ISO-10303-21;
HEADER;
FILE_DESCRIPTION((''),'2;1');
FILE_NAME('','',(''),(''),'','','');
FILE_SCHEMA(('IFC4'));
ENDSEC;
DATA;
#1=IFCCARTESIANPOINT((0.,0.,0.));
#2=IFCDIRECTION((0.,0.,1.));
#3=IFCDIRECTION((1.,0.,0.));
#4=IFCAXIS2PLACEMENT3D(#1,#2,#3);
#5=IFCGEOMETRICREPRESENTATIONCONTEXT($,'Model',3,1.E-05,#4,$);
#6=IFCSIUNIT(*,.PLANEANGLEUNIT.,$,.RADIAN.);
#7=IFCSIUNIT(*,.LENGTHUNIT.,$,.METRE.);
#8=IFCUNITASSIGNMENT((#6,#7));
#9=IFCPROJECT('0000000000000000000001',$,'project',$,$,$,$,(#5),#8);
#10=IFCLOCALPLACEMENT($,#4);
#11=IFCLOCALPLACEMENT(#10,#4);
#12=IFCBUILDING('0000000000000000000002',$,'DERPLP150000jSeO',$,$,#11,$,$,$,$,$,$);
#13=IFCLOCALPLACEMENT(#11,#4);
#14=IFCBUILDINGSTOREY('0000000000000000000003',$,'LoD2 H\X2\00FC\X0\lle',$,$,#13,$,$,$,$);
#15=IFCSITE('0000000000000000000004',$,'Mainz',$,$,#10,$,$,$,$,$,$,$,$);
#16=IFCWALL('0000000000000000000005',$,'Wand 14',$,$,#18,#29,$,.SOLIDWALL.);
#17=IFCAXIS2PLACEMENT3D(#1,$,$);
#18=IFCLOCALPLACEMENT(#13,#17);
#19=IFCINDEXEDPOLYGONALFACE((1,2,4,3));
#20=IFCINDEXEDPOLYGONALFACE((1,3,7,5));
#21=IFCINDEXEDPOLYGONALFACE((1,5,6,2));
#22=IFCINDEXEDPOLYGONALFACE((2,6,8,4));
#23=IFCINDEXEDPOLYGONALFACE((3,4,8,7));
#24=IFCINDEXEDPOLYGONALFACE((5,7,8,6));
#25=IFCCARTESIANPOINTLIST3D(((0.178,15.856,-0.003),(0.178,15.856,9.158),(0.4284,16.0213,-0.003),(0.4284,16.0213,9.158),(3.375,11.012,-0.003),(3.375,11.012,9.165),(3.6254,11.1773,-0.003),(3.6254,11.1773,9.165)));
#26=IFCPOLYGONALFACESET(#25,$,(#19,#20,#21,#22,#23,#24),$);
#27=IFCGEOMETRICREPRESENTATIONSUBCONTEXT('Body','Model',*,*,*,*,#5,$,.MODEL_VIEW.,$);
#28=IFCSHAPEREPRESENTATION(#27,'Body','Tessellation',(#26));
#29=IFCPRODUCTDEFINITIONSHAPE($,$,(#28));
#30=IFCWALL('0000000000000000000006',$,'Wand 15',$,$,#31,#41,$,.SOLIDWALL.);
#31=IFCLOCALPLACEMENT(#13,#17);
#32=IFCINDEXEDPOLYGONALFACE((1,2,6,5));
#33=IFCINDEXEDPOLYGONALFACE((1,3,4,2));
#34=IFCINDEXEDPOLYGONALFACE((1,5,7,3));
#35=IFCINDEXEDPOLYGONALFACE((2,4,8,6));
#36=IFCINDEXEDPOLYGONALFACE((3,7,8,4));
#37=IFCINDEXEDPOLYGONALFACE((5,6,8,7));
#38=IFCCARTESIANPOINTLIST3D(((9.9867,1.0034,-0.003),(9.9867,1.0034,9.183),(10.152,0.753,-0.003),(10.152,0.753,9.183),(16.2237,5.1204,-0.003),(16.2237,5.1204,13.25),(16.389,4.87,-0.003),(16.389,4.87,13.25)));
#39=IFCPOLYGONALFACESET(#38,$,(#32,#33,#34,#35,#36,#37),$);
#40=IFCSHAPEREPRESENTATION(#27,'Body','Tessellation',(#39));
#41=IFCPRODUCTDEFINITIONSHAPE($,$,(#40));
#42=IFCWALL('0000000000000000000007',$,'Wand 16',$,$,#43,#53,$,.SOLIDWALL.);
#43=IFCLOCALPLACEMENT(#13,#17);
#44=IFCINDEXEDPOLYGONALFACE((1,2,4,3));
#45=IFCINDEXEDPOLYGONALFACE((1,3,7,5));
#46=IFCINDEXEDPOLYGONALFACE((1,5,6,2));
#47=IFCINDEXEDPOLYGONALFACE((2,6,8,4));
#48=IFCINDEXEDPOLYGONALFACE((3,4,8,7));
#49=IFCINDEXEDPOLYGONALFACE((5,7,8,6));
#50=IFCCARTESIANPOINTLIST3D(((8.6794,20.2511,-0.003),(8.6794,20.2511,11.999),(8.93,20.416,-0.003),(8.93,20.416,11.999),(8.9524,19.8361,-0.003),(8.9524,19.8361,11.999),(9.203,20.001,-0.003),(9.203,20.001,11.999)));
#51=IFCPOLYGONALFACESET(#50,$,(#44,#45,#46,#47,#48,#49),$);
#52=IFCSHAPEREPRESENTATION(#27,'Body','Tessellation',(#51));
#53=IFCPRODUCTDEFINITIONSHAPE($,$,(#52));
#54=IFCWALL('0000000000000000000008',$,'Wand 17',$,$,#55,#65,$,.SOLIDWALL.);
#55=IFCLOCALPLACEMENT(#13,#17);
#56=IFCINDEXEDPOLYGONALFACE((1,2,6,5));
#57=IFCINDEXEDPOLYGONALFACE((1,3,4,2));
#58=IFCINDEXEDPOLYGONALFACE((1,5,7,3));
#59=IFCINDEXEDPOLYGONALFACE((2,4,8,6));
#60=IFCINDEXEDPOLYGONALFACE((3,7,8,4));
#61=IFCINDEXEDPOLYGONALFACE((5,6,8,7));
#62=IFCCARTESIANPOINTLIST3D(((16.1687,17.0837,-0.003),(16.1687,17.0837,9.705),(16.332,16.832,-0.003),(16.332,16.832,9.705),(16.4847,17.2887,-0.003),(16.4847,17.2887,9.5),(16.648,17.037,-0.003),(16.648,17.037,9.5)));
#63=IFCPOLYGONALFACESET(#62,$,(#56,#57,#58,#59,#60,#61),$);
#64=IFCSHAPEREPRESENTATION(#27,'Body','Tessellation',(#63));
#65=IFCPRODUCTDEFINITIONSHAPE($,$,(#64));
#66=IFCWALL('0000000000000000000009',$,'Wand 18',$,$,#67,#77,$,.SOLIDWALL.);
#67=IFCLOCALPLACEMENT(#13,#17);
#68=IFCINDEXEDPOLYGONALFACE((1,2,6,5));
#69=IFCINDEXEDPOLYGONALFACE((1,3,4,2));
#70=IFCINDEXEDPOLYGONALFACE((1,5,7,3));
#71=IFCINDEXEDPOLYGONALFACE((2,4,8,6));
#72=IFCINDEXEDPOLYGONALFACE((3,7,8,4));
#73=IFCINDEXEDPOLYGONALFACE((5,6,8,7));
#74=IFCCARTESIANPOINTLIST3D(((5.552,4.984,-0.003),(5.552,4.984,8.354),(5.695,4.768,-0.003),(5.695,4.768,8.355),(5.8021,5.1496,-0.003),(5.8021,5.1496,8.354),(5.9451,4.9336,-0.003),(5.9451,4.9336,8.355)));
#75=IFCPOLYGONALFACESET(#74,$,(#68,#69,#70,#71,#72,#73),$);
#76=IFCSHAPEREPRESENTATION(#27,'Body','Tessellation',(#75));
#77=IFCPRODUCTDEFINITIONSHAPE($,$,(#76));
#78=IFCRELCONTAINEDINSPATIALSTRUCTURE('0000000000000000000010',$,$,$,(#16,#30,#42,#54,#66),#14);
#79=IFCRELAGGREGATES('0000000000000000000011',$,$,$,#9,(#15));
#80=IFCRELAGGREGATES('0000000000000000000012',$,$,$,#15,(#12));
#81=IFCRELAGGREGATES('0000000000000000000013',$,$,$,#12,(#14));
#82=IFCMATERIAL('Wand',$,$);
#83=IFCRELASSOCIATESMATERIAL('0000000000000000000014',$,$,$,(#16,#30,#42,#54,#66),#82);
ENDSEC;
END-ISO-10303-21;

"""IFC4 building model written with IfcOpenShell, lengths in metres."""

from ifc_helpers import new_model, si_unit, frame, origin_with_axes, place, context, subcontext, project, spatial, polyline, outline, extrude, material, element, save


model = new_model("IFC4")

# Units and contexts
model_context = context("Model", 3, precision=1e-05, world=origin_with_axes())
body_context = subcontext(model_context, "Body", "Model", "MODEL_VIEW")
ifc_project = project(units=[si_unit("PLANEANGLEUNIT", "RADIAN"), si_unit("LENGTHUNIT", "METRE")], contexts=[model_context])

# Site, building, storey
site_placement = place(None, origin_with_axes())
site = spatial("IfcSite", under=ifc_project, at=site_placement, Name="Mainz")
building_placement = place(site_placement, origin_with_axes())
building = spatial("IfcBuilding", under=site, at=building_placement, Name="DERPLP150000jSeO")
storey_placement = place(building_placement, origin_with_axes())
storey = spatial("IfcBuildingStorey", under=building, at=storey_placement, Name="LoD2 Hülle")

# Walls
ifc_material_1 = material(Name="Wand")
wall_1_placement = place(storey_placement, origin_with_axes())
element("IfcWall", 1, at=wall_1_placement, inside=storey, material=ifc_material_1, Name="Wand 14", PredefinedType="SOLIDWALL", context=body_context, shape_type="SweptSolid", body=[
    extrude(outline(polyline([(0.0, 0.0), (5.8039, 0.0), (5.8149, 9.161), (0.0111, 9.168), (0.0, 0.0)])), frame((3.375, 11.012, 9.165), z_axis=(-0.834613, -0.550837, 0.0), x_axis=(-0.550837, 0.834612, -0.001206)), (0.0, 0.0, -1.0), 0.3),
])
wall_2_placement = place(storey_placement, origin_with_axes())
element("IfcWall", 2, at=wall_2_placement, inside=storey, material=ifc_material_1, Name="Wand 15", PredefinedType="SOLIDWALL", context=body_context, shape_type="SweptSolid", body=[
    extrude(outline(polyline([(0.0, 0.0), (8.5083, 0.0), (12.8992, 8.0686), (6.335, 11.6409), (0.0, 0.0)])), frame((16.389, 4.87, 13.25), z_axis=(0.550896, -0.834574, 0.0), x_axis=(-0.733053, -0.483883, -0.478007)), (0.0, 0.0, -1.0), 0.3),
])
wall_3_placement = place(storey_placement, origin_with_axes())
element("IfcWall", 3, at=wall_3_placement, inside=storey, material=ifc_material_1, Name="Wand 16", PredefinedType="SOLIDWALL", context=body_context, shape_type="SweptSolid", body=[
    extrude(outline(polyline([(0.0, 0.0), (0.4967, 0.0), (0.4967, 12.002), (0.0, 12.002), (0.0, 0.0)])), frame((8.93, 20.416, 11.999), z_axis=(0.835441, 0.54958, 0.0), x_axis=(0.54958, -0.835441, 0.0)), (0.0, 0.0, -1.0), 0.3),
])
wall_4_placement = place(storey_placement, origin_with_axes())
element("IfcWall", 4, at=wall_4_placement, inside=storey, material=ifc_material_1, Name="Wand 17", PredefinedType="SOLIDWALL", context=body_context, shape_type="SweptSolid", body=[
    extrude(outline(polyline([(0.0, 0.0), (0.4288, 0.0), (-4.2119, 8.527), (-4.5427, 8.3469), (0.0, 0.0)])), frame((16.648, 17.037, 9.5), z_axis=(0.544242, -0.838929, 0.0), x_axis=(-0.736867, -0.478031, 0.478031)), (0.0, 0.0, -1.0), 0.3),
])
wall_5_placement = place(storey_placement, origin_with_axes())
element("IfcWall", 5, at=wall_5_placement, inside=storey, material=ifc_material_1, Name="Wand 18", PredefinedType="SOLIDWALL", context=body_context, shape_type="SweptSolid", body=[
    extrude(outline(polyline([(0.0, 0.0), (0.259, 0.0), (0.2913, 8.3569), (0.0323, 8.3579), (0.0, 0.0)])), frame((5.695, 4.768, 8.355), z_axis=(-0.833828, -0.552025, 0.0), x_axis=(-0.552021, 0.833821, -0.00386)), (0.0, 0.0, -1.0), 0.3),
])

save(model, "model.ifc")
